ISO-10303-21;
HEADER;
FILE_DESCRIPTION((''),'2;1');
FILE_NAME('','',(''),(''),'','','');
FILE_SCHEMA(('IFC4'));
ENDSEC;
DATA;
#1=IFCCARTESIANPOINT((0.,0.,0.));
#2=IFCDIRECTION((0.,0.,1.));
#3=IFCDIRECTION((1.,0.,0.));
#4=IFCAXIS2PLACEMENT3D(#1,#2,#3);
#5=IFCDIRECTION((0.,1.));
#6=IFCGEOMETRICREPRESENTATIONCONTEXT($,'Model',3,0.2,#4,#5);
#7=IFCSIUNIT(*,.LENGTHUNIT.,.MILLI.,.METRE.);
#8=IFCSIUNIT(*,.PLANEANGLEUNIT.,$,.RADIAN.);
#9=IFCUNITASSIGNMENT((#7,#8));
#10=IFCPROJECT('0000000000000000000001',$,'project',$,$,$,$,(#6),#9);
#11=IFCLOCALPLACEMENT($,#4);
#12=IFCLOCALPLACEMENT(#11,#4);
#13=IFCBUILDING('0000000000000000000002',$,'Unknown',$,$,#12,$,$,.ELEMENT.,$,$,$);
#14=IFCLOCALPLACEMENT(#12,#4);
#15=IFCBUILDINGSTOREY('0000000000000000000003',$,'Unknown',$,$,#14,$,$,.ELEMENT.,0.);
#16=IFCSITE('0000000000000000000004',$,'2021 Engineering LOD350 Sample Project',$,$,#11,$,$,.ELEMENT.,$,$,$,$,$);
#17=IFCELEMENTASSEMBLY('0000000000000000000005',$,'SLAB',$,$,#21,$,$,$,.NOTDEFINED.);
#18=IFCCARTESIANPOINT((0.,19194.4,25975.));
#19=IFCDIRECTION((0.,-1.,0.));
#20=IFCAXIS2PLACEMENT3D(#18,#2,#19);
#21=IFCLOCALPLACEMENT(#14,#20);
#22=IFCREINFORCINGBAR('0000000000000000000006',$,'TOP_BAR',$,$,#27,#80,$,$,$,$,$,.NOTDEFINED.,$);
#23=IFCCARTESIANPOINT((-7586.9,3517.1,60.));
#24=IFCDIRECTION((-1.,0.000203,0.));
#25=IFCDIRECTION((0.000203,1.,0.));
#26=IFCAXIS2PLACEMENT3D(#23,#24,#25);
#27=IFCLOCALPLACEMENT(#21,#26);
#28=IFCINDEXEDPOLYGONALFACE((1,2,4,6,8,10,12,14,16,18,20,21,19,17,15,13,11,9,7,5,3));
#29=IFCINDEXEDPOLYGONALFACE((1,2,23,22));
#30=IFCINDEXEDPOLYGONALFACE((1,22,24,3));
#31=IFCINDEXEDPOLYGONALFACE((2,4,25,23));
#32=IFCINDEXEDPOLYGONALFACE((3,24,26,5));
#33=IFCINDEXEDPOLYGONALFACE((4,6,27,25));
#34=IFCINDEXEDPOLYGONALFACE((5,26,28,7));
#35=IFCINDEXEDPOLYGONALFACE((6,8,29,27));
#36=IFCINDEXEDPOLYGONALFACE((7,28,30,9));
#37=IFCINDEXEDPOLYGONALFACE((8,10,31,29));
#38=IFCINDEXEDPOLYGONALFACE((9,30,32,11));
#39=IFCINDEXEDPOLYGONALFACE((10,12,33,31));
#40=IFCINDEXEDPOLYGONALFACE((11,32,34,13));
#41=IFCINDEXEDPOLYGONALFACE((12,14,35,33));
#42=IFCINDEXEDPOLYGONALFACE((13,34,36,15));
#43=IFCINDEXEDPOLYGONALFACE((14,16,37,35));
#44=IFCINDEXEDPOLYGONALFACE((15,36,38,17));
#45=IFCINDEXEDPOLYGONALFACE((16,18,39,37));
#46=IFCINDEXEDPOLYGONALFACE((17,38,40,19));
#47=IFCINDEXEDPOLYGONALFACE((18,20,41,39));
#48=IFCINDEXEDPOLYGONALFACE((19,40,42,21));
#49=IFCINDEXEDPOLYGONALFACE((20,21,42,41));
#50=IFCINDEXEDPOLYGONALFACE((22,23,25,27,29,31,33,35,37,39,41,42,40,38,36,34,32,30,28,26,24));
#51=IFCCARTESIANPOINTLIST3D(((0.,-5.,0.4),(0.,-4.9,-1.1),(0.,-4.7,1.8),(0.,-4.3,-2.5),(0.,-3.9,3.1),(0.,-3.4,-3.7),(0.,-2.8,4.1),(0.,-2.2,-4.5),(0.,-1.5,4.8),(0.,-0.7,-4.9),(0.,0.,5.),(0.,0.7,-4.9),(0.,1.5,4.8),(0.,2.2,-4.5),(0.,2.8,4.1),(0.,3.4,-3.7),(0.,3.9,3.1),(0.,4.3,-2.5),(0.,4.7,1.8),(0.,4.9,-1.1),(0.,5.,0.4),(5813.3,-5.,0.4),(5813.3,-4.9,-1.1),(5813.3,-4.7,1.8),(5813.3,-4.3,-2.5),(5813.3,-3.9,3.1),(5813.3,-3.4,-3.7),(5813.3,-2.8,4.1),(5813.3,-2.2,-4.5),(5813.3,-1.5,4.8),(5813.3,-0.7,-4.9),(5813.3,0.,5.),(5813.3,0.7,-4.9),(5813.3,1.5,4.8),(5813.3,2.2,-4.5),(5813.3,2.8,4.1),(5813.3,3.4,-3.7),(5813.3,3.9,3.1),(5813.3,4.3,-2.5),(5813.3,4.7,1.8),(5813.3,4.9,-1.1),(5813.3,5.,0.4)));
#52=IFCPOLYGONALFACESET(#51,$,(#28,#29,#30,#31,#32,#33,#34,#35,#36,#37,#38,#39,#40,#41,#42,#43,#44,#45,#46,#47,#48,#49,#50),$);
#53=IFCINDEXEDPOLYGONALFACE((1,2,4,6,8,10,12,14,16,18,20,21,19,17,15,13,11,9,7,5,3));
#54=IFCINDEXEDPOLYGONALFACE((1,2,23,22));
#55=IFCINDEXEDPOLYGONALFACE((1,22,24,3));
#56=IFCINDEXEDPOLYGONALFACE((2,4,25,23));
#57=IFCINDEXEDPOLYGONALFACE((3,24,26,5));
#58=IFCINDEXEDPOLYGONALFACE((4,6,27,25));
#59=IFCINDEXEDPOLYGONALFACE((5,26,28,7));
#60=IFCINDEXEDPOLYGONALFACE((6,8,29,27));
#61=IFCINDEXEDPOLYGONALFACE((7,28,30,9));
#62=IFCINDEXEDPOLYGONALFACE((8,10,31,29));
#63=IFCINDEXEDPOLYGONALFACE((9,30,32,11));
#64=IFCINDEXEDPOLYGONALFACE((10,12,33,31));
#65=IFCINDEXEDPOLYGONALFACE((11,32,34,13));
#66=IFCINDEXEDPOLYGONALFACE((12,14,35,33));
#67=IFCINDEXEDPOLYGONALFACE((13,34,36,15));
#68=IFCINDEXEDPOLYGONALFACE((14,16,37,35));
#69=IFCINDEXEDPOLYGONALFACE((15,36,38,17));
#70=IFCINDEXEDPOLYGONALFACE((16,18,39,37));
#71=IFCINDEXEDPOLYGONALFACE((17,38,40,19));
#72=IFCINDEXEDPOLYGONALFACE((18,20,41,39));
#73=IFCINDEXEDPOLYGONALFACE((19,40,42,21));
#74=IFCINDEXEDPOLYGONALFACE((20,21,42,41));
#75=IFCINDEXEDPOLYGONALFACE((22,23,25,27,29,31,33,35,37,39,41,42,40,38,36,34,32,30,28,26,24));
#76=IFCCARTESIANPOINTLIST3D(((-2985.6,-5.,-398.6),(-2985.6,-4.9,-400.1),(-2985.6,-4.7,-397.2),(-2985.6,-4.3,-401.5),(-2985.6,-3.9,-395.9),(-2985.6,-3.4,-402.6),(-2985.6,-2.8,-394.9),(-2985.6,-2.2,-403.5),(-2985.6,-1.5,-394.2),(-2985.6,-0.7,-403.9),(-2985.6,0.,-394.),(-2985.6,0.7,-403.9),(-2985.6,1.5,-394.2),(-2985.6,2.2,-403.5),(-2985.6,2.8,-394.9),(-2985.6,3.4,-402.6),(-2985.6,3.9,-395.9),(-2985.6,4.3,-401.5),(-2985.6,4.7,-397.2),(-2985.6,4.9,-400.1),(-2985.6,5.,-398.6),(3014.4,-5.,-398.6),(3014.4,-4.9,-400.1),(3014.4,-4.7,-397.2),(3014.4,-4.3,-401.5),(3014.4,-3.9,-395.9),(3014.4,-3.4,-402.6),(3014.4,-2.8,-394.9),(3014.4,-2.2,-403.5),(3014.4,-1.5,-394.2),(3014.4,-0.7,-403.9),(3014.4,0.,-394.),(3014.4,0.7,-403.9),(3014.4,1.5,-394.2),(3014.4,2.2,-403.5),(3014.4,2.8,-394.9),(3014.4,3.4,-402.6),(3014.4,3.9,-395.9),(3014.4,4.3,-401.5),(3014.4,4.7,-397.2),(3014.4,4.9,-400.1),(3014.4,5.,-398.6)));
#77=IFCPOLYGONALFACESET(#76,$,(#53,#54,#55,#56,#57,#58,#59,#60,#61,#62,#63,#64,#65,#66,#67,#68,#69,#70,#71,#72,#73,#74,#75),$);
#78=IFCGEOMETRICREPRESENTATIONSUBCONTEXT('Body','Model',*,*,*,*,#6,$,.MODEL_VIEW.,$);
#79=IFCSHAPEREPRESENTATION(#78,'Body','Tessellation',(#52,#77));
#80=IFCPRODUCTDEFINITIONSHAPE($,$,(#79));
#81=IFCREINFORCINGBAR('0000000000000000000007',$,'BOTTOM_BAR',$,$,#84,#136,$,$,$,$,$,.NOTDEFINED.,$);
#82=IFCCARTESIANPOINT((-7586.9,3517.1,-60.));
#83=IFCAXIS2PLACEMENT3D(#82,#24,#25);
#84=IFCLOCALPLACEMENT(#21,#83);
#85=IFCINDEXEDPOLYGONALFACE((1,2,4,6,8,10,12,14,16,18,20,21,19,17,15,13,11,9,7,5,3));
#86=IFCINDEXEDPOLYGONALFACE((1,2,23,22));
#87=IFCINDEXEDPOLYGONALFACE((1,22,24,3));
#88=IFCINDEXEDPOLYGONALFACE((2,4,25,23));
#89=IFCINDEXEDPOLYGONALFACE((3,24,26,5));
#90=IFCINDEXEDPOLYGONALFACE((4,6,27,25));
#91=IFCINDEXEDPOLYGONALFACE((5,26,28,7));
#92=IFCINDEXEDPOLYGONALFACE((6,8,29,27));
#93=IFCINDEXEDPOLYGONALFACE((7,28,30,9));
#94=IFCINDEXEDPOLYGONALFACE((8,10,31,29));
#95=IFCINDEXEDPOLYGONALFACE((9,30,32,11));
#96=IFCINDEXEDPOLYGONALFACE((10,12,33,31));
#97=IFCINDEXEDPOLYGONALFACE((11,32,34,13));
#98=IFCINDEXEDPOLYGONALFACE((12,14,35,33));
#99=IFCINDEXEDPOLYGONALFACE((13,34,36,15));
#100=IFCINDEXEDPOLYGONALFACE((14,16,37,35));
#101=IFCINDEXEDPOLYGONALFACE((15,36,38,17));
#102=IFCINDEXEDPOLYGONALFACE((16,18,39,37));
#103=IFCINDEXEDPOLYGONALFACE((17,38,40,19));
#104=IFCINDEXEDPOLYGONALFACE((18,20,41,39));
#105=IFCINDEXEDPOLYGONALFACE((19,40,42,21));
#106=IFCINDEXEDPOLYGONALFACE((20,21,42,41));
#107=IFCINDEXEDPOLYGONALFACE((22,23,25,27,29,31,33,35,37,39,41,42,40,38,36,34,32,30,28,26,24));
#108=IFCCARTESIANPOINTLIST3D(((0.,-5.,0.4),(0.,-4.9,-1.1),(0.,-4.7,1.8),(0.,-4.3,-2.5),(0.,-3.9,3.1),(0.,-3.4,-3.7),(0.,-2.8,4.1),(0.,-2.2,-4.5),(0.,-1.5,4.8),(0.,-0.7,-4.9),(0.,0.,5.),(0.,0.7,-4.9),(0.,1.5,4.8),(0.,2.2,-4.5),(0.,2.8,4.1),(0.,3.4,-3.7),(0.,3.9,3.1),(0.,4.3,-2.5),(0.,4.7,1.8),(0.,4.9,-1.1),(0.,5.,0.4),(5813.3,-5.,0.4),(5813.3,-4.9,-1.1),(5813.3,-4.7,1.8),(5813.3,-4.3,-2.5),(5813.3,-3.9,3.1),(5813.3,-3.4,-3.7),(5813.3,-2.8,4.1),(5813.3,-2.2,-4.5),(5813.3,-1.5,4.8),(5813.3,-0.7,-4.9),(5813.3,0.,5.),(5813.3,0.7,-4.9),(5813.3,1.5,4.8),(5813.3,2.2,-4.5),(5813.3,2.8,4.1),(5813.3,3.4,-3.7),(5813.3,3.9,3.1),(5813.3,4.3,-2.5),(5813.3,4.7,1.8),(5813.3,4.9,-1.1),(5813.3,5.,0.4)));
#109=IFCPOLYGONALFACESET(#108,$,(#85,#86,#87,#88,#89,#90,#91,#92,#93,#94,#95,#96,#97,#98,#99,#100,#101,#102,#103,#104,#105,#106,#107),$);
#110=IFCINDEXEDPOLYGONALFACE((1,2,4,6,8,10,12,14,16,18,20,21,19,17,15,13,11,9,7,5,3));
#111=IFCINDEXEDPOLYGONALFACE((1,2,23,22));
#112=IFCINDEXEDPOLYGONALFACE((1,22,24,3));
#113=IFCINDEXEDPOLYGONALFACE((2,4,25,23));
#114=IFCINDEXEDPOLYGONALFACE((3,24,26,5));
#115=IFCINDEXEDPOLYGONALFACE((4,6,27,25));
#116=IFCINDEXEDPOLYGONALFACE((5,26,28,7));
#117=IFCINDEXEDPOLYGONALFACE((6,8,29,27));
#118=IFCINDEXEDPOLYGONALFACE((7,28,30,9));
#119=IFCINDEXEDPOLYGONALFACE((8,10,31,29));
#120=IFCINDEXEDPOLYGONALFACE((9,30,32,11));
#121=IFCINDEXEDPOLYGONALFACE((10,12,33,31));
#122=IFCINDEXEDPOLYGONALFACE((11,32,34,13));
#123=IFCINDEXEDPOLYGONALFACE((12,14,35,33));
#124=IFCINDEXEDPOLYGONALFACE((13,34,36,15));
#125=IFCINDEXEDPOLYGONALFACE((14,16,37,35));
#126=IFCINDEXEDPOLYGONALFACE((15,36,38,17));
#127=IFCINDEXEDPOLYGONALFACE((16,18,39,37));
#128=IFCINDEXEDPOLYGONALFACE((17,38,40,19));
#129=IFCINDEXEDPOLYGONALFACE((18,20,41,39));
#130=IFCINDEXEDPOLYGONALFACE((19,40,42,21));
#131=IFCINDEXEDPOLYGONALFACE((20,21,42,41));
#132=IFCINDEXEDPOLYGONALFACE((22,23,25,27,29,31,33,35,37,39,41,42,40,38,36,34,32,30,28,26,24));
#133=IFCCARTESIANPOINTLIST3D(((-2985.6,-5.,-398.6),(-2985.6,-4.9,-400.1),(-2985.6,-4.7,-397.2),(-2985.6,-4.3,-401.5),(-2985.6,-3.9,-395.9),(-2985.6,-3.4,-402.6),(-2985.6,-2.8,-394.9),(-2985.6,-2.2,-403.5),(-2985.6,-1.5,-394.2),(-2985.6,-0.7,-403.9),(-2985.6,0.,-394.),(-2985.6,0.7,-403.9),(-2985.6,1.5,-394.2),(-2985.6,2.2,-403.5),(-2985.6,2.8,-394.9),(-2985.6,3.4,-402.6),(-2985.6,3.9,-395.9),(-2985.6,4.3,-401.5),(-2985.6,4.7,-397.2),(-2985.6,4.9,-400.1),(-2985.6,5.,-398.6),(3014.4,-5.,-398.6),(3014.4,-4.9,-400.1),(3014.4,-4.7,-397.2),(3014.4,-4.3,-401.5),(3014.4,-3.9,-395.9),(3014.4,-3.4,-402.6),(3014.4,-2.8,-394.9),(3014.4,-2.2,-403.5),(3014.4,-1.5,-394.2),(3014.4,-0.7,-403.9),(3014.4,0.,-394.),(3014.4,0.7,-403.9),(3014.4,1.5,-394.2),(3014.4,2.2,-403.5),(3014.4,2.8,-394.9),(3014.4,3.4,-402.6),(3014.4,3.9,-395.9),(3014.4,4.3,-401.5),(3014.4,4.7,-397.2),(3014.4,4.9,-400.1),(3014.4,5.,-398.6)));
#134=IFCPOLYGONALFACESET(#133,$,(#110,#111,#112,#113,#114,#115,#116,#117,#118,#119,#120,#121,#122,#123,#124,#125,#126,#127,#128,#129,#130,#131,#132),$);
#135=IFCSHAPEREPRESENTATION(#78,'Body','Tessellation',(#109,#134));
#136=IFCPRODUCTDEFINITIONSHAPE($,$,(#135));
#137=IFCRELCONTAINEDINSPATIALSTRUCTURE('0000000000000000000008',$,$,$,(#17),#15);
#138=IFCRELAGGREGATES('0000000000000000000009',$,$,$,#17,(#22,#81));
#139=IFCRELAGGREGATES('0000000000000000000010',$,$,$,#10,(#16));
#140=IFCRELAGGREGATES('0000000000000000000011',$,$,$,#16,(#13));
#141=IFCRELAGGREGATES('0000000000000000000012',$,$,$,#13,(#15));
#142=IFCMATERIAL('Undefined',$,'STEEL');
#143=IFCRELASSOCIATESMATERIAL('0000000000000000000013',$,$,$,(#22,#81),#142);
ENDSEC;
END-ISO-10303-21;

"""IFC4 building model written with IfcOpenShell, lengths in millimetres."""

from ifc_helpers import new_model, entity, si_unit, direction, frame, origin_with_axes, place, context, subcontext, project, spatial, material, element, aggregate, save


model = new_model("IFC4")

# Units and contexts
model_context = context("Model", 3, precision=0.2, world=origin_with_axes(), true_north=direction((0.0, 1.0)))
body_context = subcontext(model_context, "Body", "Model", "MODEL_VIEW")
ifc_project = project(units=[si_unit("LENGTHUNIT", "METRE", prefix="MILLI"), si_unit("PLANEANGLEUNIT", "RADIAN")], contexts=[model_context])

# Site, building, storey
site_placement = place(None, origin_with_axes())
site = spatial("IfcSite", under=ifc_project, at=site_placement, Name="2021 Engineering LOD350 Sample Project", CompositionType="ELEMENT")
building_placement = place(site_placement, origin_with_axes())
building = spatial("IfcBuilding", under=site, at=building_placement, Name="Unknown", CompositionType="ELEMENT")
storey_placement = place(building_placement, origin_with_axes())
storey = spatial("IfcBuildingStorey", under=building, at=storey_placement, Name="Unknown", CompositionType="ELEMENT", Elevation=0.0)

# Element assembly
assembly_1_placement = place(storey_placement, frame((0.0, 19194.4, 25975.0), z_axis=(0.0, 0.0, 1.0), x_axis=(0.0, -1.0, 0.0)))
assembly_1 = element("IfcElementAssembly", 1, at=assembly_1_placement, inside=storey, Name="SLAB", PredefinedType="NOTDEFINED")
ifc_material_1 = material(Name="Undefined", Category="STEEL")

# Reinforcing bars
reinforcing_bar_1_placement = place(assembly_1_placement, frame((-7586.9, 3517.1, 60.0), z_axis=(-1.0, 0.000203, 0.0), x_axis=(0.000203, 1.0, 0.0)))
reinforcing_bar_1 = element("IfcReinforcingBar", 2, at=reinforcing_bar_1_placement, material=ifc_material_1, Name="TOP_BAR", PredefinedType="NOTDEFINED", context=body_context, shape_type="AdvancedSweptSolid", body=[
    entity("IfcSweptDiskSolid", entity("IfcIndexedPolyCurve", entity("IfcCartesianPointList3D", [[0.0, 0.0, 0.0], [5813.3, 0.0, 0.0]]), [entity("IfcLineIndex", [1, 2])]), 5.0),
    entity("IfcSweptDiskSolid", entity("IfcIndexedPolyCurve", entity("IfcCartesianPointList3D", [[-2985.6, 0.0, -399.0], [3014.4, 0.0, -399.0]]), [entity("IfcLineIndex", [1, 2])]), 5.0),
])
reinforcing_bar_2_placement = place(assembly_1_placement, frame((-7586.9, 3517.1, -60.0), z_axis=(-1.0, 0.000203, 0.0), x_axis=(0.000203, 1.0, 0.0)))
reinforcing_bar_2 = element("IfcReinforcingBar", 3, at=reinforcing_bar_2_placement, material=ifc_material_1, Name="BOTTOM_BAR", PredefinedType="NOTDEFINED", context=body_context, shape_type="AdvancedSweptSolid", body=[
    entity("IfcSweptDiskSolid", entity("IfcIndexedPolyCurve", entity("IfcCartesianPointList3D", [[0.0, 0.0, 0.0], [5813.3, 0.0, 0.0]]), [entity("IfcLineIndex", [1, 2])]), 5.0),
    entity("IfcSweptDiskSolid", entity("IfcIndexedPolyCurve", entity("IfcCartesianPointList3D", [[-2985.6, 0.0, -399.0], [3014.4, 0.0, -399.0]]), [entity("IfcLineIndex", [1, 2])]), 5.0),
])
aggregate(assembly_1, [reinforcing_bar_1, reinforcing_bar_2])

save(model, "model.ifc")
